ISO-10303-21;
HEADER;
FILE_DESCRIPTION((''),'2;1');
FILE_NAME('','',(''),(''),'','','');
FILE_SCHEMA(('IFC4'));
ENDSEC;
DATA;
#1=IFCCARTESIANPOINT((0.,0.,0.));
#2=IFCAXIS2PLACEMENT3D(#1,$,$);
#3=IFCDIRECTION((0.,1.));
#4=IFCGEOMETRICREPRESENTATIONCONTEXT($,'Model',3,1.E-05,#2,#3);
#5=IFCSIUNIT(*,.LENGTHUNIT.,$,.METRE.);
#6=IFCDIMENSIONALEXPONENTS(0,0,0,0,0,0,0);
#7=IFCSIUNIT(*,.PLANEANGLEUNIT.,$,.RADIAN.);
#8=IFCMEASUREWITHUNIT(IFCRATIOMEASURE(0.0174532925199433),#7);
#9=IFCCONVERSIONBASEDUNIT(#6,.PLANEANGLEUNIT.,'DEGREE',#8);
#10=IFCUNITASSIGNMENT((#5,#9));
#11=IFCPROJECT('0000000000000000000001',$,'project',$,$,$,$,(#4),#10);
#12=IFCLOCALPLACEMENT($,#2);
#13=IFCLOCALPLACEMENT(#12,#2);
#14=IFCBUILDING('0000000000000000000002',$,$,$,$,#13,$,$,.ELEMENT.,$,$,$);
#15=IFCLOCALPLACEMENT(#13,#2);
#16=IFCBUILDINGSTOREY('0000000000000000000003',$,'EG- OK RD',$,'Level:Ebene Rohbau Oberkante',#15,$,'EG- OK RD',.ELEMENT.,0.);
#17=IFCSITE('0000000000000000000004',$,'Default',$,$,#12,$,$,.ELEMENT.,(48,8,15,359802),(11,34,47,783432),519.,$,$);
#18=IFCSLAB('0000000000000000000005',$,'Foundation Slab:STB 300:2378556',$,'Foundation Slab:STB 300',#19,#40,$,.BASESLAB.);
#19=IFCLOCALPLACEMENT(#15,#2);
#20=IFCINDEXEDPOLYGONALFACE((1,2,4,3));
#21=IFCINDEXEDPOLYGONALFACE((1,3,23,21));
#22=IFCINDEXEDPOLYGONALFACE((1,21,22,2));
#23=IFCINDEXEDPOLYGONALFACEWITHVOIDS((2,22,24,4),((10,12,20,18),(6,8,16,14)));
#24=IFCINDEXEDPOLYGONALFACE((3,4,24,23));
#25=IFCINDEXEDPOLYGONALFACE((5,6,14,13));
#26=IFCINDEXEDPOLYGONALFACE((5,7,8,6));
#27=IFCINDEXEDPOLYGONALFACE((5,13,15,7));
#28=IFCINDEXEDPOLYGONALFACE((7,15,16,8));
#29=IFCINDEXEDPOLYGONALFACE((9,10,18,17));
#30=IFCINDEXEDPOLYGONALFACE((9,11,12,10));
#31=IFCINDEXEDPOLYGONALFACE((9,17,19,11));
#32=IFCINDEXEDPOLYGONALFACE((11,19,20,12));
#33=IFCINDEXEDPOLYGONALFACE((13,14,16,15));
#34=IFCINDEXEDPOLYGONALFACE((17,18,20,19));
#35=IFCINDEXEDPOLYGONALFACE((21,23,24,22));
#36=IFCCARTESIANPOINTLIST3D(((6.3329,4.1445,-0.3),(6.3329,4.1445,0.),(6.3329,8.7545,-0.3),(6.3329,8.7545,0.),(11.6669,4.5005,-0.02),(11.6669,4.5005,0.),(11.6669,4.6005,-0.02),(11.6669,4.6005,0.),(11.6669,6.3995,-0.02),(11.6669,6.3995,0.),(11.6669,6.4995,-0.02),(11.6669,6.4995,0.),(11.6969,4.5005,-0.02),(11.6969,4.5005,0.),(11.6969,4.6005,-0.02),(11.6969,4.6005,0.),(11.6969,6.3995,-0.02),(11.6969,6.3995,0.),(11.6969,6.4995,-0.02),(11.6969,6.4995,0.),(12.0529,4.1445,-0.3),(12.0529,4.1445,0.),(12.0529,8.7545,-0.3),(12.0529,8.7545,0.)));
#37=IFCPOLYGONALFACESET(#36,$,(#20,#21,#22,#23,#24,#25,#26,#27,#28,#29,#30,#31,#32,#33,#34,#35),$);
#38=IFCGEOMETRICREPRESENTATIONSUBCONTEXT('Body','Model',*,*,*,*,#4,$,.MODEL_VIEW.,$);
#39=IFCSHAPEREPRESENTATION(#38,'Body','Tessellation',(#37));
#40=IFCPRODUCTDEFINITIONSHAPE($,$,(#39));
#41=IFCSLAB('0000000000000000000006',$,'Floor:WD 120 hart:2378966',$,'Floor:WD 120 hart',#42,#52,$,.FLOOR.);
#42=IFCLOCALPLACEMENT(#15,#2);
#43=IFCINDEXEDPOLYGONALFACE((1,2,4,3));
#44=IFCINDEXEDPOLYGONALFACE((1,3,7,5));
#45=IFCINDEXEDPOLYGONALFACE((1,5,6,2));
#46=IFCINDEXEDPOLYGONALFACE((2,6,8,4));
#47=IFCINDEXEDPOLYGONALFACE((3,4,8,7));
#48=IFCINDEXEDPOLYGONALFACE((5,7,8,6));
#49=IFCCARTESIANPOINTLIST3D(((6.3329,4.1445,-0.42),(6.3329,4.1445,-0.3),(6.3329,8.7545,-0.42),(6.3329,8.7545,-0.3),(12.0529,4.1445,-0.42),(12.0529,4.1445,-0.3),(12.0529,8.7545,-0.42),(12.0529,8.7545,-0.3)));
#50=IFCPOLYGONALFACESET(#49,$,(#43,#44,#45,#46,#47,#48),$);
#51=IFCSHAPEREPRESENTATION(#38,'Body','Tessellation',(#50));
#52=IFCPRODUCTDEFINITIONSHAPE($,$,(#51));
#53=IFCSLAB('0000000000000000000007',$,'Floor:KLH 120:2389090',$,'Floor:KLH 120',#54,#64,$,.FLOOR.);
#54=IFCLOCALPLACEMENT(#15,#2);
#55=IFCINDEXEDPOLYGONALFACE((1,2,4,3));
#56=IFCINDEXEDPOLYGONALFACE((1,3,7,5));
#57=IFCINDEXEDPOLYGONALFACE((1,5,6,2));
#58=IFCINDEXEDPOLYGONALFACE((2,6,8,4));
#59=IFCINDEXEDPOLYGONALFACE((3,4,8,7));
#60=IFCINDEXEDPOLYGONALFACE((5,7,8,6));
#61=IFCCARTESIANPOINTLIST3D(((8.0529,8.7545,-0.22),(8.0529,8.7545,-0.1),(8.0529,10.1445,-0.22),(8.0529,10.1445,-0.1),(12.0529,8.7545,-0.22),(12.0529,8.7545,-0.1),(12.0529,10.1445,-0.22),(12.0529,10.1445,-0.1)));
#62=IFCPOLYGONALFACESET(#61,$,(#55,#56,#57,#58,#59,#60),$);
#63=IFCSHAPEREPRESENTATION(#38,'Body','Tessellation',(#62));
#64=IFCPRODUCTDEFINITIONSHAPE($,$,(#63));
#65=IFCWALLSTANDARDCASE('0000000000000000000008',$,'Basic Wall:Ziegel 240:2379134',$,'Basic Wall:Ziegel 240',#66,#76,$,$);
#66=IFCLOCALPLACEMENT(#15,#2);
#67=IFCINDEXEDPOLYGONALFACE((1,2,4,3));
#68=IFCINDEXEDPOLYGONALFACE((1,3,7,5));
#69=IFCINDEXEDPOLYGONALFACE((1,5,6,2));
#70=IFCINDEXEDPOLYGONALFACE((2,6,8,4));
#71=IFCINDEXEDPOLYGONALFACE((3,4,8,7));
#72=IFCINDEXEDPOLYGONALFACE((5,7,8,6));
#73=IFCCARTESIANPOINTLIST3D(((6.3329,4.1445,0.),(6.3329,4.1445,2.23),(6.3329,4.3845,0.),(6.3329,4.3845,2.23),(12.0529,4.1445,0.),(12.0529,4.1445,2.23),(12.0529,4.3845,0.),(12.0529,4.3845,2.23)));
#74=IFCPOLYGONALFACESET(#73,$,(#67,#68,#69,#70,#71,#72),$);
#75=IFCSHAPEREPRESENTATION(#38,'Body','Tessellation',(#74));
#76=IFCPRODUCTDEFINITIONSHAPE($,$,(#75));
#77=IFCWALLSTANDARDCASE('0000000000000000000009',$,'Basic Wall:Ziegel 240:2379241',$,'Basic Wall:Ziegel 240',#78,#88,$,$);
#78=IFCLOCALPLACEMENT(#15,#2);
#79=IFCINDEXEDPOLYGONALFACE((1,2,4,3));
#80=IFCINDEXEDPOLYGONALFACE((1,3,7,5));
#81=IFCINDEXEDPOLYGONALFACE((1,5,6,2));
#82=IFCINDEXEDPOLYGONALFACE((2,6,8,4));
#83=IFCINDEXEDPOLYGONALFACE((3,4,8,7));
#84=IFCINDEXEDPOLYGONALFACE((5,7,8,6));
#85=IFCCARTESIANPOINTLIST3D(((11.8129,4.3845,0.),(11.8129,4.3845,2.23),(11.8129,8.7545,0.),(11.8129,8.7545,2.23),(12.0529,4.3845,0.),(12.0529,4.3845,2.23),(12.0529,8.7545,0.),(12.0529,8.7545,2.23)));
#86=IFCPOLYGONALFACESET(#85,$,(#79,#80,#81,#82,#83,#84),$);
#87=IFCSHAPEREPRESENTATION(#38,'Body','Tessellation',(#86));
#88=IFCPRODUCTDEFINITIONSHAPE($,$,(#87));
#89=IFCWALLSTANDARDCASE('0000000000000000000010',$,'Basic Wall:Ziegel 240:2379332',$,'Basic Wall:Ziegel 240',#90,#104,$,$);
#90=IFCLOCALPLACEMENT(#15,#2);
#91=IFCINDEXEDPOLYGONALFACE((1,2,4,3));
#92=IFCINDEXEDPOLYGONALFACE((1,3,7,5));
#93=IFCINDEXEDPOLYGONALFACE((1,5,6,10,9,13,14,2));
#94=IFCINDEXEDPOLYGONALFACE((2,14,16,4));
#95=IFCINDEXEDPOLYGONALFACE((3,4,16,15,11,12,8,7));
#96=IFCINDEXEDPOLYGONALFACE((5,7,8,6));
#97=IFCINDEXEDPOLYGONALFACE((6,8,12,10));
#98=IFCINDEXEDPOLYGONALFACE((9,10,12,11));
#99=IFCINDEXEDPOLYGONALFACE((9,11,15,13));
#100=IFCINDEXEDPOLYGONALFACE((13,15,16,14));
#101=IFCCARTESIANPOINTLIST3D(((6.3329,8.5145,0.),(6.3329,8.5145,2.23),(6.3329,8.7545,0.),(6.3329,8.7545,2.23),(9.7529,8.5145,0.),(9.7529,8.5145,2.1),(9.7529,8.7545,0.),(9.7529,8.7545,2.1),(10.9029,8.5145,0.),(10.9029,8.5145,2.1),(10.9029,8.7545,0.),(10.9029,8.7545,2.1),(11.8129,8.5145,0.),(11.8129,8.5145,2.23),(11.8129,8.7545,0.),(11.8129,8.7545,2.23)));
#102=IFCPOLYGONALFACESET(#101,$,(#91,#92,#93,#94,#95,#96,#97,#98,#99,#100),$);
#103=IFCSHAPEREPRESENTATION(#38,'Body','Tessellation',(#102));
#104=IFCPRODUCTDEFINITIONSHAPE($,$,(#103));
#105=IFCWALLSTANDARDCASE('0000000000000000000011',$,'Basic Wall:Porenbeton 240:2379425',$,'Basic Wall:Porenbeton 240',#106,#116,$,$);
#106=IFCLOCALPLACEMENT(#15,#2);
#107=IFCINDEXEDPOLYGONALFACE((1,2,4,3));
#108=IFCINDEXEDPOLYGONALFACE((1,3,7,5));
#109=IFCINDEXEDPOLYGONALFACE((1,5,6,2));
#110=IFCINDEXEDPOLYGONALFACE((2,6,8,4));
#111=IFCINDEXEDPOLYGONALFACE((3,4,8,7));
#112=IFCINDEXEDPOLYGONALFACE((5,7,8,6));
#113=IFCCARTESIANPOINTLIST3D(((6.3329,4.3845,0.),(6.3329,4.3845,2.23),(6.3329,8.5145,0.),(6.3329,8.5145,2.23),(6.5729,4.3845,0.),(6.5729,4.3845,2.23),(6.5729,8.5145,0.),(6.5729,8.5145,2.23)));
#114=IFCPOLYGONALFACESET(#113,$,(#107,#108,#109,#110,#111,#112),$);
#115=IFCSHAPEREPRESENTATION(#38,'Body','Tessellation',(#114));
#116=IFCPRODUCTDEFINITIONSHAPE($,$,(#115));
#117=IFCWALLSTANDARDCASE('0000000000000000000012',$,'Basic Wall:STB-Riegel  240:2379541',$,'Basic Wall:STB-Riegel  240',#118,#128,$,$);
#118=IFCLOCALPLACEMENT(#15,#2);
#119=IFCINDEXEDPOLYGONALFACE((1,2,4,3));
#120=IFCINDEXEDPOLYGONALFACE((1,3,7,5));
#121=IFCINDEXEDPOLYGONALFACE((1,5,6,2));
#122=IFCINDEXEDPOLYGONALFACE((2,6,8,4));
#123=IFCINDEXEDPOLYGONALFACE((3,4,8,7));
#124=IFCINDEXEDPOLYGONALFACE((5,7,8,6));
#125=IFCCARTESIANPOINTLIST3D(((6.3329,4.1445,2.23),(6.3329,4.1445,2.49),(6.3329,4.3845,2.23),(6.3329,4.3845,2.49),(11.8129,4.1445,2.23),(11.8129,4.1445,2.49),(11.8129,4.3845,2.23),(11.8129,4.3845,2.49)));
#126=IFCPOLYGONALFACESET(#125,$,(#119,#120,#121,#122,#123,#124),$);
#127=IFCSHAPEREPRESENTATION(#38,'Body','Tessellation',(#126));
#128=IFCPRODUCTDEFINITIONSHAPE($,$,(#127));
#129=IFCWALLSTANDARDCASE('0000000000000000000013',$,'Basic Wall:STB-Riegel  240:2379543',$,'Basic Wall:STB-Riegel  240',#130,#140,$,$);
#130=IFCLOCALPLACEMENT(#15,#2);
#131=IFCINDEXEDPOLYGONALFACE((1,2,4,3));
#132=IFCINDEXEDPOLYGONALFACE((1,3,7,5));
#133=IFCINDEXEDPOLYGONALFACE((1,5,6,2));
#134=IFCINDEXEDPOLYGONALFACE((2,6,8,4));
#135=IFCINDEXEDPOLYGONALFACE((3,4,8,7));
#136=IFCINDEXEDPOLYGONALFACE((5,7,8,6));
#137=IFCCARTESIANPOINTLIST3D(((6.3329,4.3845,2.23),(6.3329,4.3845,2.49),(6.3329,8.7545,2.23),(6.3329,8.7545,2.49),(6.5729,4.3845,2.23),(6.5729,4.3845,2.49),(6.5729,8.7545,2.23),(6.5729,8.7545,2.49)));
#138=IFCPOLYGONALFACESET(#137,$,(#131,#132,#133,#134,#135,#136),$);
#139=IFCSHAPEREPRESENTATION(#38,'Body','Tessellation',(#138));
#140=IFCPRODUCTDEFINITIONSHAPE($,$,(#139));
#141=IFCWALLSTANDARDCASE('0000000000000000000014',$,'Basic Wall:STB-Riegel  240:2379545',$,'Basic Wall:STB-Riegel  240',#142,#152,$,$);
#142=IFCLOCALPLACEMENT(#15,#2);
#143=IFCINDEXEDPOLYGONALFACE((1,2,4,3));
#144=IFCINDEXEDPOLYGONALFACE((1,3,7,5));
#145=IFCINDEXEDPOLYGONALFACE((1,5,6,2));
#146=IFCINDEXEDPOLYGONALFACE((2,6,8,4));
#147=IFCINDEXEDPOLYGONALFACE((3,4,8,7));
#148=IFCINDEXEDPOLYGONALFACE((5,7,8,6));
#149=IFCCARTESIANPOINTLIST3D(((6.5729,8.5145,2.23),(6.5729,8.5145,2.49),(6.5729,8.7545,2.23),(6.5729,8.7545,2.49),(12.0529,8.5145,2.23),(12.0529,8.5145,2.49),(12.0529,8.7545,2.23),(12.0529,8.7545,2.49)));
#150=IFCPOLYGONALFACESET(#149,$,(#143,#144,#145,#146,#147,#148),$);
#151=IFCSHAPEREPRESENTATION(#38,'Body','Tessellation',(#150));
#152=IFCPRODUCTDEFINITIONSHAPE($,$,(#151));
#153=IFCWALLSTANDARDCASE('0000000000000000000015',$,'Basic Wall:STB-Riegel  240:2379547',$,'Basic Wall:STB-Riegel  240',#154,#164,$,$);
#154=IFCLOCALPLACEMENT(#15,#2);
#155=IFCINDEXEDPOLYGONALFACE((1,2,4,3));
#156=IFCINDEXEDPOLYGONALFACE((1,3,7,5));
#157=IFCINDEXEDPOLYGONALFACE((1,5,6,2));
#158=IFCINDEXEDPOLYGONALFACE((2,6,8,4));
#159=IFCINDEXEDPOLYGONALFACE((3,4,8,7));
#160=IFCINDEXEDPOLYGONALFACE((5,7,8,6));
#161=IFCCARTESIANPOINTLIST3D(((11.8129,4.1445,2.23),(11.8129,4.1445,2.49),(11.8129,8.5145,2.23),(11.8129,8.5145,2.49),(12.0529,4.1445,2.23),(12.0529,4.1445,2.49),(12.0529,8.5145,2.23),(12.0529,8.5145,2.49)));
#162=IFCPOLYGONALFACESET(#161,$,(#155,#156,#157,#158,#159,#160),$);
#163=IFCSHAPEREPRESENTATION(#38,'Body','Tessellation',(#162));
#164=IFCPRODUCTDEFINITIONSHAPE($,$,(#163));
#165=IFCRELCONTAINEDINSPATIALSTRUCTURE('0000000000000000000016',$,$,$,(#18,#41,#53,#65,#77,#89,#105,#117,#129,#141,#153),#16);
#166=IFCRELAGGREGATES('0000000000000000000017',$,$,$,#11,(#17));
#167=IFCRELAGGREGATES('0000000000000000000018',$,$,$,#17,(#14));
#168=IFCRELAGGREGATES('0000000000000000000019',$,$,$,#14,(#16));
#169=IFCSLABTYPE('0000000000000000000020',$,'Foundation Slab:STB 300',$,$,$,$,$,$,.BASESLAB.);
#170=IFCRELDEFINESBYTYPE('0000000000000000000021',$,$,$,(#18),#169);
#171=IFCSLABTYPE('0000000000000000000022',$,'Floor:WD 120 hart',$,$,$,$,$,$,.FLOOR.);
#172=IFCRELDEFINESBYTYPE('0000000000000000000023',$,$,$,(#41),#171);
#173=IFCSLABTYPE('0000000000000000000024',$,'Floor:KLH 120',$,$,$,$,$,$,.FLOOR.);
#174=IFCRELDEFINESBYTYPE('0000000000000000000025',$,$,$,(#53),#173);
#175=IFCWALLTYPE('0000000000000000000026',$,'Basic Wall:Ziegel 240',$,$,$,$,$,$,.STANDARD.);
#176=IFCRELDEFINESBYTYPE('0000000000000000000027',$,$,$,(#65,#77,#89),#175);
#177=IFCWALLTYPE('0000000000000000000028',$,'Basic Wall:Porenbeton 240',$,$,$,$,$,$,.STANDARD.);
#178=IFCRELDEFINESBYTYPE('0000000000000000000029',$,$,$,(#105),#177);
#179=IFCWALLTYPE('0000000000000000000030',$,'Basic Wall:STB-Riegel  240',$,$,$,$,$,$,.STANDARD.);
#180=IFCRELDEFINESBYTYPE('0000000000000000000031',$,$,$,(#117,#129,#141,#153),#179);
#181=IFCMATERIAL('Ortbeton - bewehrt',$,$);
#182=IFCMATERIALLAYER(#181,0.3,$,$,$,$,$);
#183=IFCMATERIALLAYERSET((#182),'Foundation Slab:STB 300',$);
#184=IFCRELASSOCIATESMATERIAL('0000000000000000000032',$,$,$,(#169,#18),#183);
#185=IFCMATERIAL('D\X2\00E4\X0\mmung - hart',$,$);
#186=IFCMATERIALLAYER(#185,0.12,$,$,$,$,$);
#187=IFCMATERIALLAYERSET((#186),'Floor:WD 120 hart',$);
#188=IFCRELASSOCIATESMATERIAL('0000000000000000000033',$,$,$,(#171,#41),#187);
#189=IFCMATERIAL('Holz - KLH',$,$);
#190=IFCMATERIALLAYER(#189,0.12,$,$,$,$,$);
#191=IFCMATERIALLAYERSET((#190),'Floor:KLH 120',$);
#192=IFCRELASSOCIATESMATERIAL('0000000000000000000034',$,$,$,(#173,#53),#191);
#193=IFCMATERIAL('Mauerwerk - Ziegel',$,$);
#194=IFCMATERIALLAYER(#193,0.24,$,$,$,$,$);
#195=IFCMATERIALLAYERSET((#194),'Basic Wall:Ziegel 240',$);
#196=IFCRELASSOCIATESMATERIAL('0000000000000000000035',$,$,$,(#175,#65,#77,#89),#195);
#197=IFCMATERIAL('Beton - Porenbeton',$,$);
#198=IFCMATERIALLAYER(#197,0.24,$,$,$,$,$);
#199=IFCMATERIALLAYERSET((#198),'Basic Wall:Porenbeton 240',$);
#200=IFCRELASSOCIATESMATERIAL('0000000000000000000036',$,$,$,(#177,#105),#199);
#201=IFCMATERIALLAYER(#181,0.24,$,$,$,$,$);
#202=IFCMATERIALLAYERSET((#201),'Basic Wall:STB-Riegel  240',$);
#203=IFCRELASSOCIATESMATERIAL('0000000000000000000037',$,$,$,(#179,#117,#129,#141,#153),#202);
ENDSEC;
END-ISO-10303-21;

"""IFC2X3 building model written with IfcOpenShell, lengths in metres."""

from ifc_helpers import new_model, entity, si_unit, converted_unit, direction, frame, frame_2d, origin, origin_2d_with_axis, place, context, subcontext, project, spatial, rectangle, extrude, material, layer, layer_set, layer_usage, type_object, element, save


model = new_model("IFC2X3")

# Units and contexts
model_context = context("Model", 3, precision=1e-05, world=origin(), true_north=direction((0.0, 1.0)))
body_context = subcontext(model_context, "Body", "Model", "MODEL_VIEW")
ifc_project = project(units=[si_unit("LENGTHUNIT", "METRE"), converted_unit("PLANEANGLEUNIT", "DEGREE", entity("IfcRatioMeasure", 0.0174532925199433), si_unit("PLANEANGLEUNIT", "RADIAN"), dimensions=[0, 0, 0, 0, 0, 0, 0])], contexts=[model_context])

# Site, building, storey
site_placement = place(None, origin())
site = spatial("IfcSite", under=ifc_project, at=site_placement, Name="Default", CompositionType="ELEMENT", RefLatitude=(48, 8, 15, 359802), RefLongitude=(11, 34, 47, 783432), RefElevation=519.0)
building_placement = place(site_placement, origin())
building = spatial("IfcBuilding", under=site, at=building_placement, CompositionType="ELEMENT")
storey_placement = place(building_placement, origin())
storey = spatial("IfcBuildingStorey", under=building, at=storey_placement, Name="EG- OK RD", ObjectType="Level:Ebene Rohbau Oberkante", LongName="EG- OK RD", CompositionType="ELEMENT", Elevation=0.0)

# Slab, openings
ifc_material_1 = material(Name="Ortbeton - bewehrt")
ifc_layer_1 = layer(ifc_material_1, 0.3)
ifc_layer_set_1 = layer_set([ifc_layer_1], Name="Foundation Slab:STB 300")
ifc_layer_usage_1 = layer_usage(ifc_layer_set_1, "AXIS3", "POSITIVE", 0.0)
slab_type_1 = type_object("IfcSlabType", Name="Foundation Slab:STB 300", PredefinedType="BASESLAB", material=ifc_layer_set_1)
slab_1_placement = place(storey_placement, frame((6.3329, 4.1445, -0.3)))
slab_1 = element("IfcSlab", 1, at=slab_1_placement, inside=storey, type_object=slab_type_1, material=ifc_layer_usage_1, Name="Foundation Slab:STB 300:2378556", ObjectType="Foundation Slab:STB 300", PredefinedType="BASESLAB", context=body_context, shape_type="SweptSolid", body=[
    extrude(rectangle(XDim=4.61, YDim=5.72, at=frame_2d((0.0, 0.0), x_axis=(0.0, -1.0))), frame((2.86, 2.305, 0.3), z_axis=(0.0, 0.0, -1.0), x_axis=(-1.0, 0.0, 0.0)), (0.0, 0.0, 1.0), 0.3),
])
opening_1_placement = place(slab_1_placement, origin())
element("IfcOpeningElement", 2, at=opening_1_placement, cuts=slab_1, ObjectType="Opening", context=body_context, shape_type="SweptSolid", body=[
    extrude(rectangle(XDim=0.03, YDim=0.1, at=origin_2d_with_axis()), frame((5.349, 2.305, 0.28), z_axis=(0.0, 0.0, 1.0), x_axis=(-1.0, 0.0, 0.0)), (0.0, 0.0, 1.0), 0.52),
])
opening_2_placement = place(slab_1_placement, origin())
element("IfcOpeningElement", 3, at=opening_2_placement, cuts=slab_1, ObjectType="Recess", context=body_context, shape_type="SweptSolid", body=[
    extrude(rectangle(XDim=0.03, YDim=0.1, at=origin_2d_with_axis()), frame((5.349, 0.406, 0.28), z_axis=(0.0, 0.0, 1.0), x_axis=(-1.0, 0.0, 0.0)), (0.0, 0.0, 1.0), 0.52),
])

# Slabs
ifc_material_2 = material(Name="Dämmung - hart")
ifc_layer_2 = layer(ifc_material_2, 0.12)
ifc_layer_set_2 = layer_set([ifc_layer_2], Name="Floor:WD 120 hart")
ifc_layer_usage_2 = layer_usage(ifc_layer_set_2, "AXIS3", "POSITIVE", 0.0)
slab_type_2 = type_object("IfcSlabType", Name="Floor:WD 120 hart", PredefinedType="FLOOR", material=ifc_layer_set_2)
slab_2_placement = place(storey_placement, origin())
element("IfcSlab", 4, at=slab_2_placement, inside=storey, type_object=slab_type_2, material=ifc_layer_usage_2, Name="Floor:WD 120 hart:2378966", ObjectType="Floor:WD 120 hart", PredefinedType="FLOOR", context=body_context, shape_type="SweptSolid", body=[
    extrude(rectangle(XDim=4.61, YDim=5.72, at=frame_2d((0.0, 0.0), x_axis=(1.0, 0.0))), frame((9.1929, 6.4495, -0.3), z_axis=(0.0, 0.0, -1.0), x_axis=(0.0, 1.0, 0.0)), (0.0, 0.0, 1.0), 0.12),
])
ifc_material_3 = material(Name="Holz - KLH")
ifc_layer_3 = layer(ifc_material_3, 0.12)
ifc_layer_set_3 = layer_set([ifc_layer_3], Name="Floor:KLH 120")
ifc_layer_usage_3 = layer_usage(ifc_layer_set_3, "AXIS3", "POSITIVE", 0.0)
slab_type_3 = type_object("IfcSlabType", Name="Floor:KLH 120", PredefinedType="FLOOR", material=ifc_layer_set_3)
slab_3_placement = place(storey_placement, origin())
element("IfcSlab", 5, at=slab_3_placement, inside=storey, type_object=slab_type_3, material=ifc_layer_usage_3, Name="Floor:KLH 120:2389090", ObjectType="Floor:KLH 120", PredefinedType="FLOOR", context=body_context, shape_type="SweptSolid", body=[
    extrude(rectangle(XDim=1.39, YDim=4.0, at=frame_2d((0.0, 0.0), x_axis=(1.0, 0.0))), frame((10.0529, 9.4495, -0.1), z_axis=(0.0, 0.0, -1.0), x_axis=(0.0, 1.0, 0.0)), (0.0, 0.0, 1.0), 0.12),
])

# Walls
ifc_material_4 = material(Name="Mauerwerk - Ziegel")
ifc_layer_4 = layer(ifc_material_4, 0.24)
ifc_layer_set_4 = layer_set([ifc_layer_4], Name="Basic Wall:Ziegel 240")
ifc_layer_usage_4 = layer_usage(ifc_layer_set_4, "AXIS2", "POSITIVE", -0.12)
wall_type_1 = type_object("IfcWallType", Name="Basic Wall:Ziegel 240", PredefinedType="STANDARD", material=ifc_layer_set_4)
wall_1_placement = place(storey_placement, frame((6.3329, 4.2645, 0.0)))
element("IfcWallStandardCase", 6, at=wall_1_placement, inside=storey, type_object=wall_type_1, material=ifc_layer_usage_4, Name="Basic Wall:Ziegel 240:2379134", ObjectType="Basic Wall:Ziegel 240", context=body_context, shape_type="SweptSolid", body=[
    extrude(rectangle(XDim=5.72, YDim=0.24, at=frame_2d((2.86, 0.0), x_axis=(-1.0, 0.0))), origin(), (0.0, 0.0, 1.0), 2.23),
])
ifc_layer_usage_5 = layer_usage(ifc_layer_set_4, "AXIS2", "POSITIVE", -0.12)
wall_2_placement = place(storey_placement, frame((11.9329, 4.3845, 0.0), z_axis=(0.0, 0.0, 1.0), x_axis=(0.0, 1.0, 0.0)))
element("IfcWallStandardCase", 7, at=wall_2_placement, inside=storey, type_object=wall_type_1, material=ifc_layer_usage_5, Name="Basic Wall:Ziegel 240:2379241", ObjectType="Basic Wall:Ziegel 240", context=body_context, shape_type="SweptSolid", body=[
    extrude(rectangle(XDim=4.37, YDim=0.24, at=frame_2d((2.185, 0.0), x_axis=(-1.0, 0.0))), origin(), (0.0, 0.0, 1.0), 2.23),
])

# Wall, opening
ifc_layer_usage_6 = layer_usage(ifc_layer_set_4, "AXIS2", "POSITIVE", -0.12)
wall_3_placement = place(storey_placement, frame((11.8129, 8.6345, 0.0), z_axis=(0.0, 0.0, 1.0), x_axis=(-1.0, 0.0, 0.0)))
wall_3 = element("IfcWallStandardCase", 8, at=wall_3_placement, inside=storey, type_object=wall_type_1, material=ifc_layer_usage_6, Name="Basic Wall:Ziegel 240:2379332", ObjectType="Basic Wall:Ziegel 240", context=body_context, shape_type="SweptSolid", body=[
    extrude(rectangle(XDim=5.48, YDim=0.24, at=frame_2d((2.74, 0.0), x_axis=(-1.0, 0.0))), origin(), (0.0, 0.0, 1.0), 2.23),
])
opening_3_placement = place(wall_3_placement, frame((0.91, -0.12, 0.0)))
element("IfcOpeningElement", 9, at=opening_3_placement, cuts=wall_3, ObjectType="Opening", context=body_context, shape_type="SweptSolid", body=[
    extrude(rectangle(XDim=2.1, YDim=1.15, at=frame_2d((1.05, 0.575), x_axis=(-1.0, 0.0))), frame((0.0, 0.0, 0.0), z_axis=(0.0, 1.0, 0.0), x_axis=(0.0, 0.0, 1.0)), (0.0, 0.0, 1.0), 0.24),
])

# Walls
ifc_material_5 = material(Name="Beton - Porenbeton")
ifc_layer_5 = layer(ifc_material_5, 0.24)
ifc_layer_set_5 = layer_set([ifc_layer_5], Name="Basic Wall:Porenbeton 240")
ifc_layer_usage_7 = layer_usage(ifc_layer_set_5, "AXIS2", "POSITIVE", -0.12)
wall_type_2 = type_object("IfcWallType", Name="Basic Wall:Porenbeton 240", PredefinedType="STANDARD", material=ifc_layer_set_5)
wall_4_placement = place(storey_placement, frame((6.4529, 8.5145, 0.0), z_axis=(0.0, 0.0, 1.0), x_axis=(0.0, -1.0, 0.0)))
element("IfcWallStandardCase", 10, at=wall_4_placement, inside=storey, type_object=wall_type_2, material=ifc_layer_usage_7, Name="Basic Wall:Porenbeton 240:2379425", ObjectType="Basic Wall:Porenbeton 240", context=body_context, shape_type="SweptSolid", body=[
    extrude(rectangle(XDim=4.13, YDim=0.24, at=frame_2d((2.065, 0.0), x_axis=(-1.0, 0.0))), origin(), (0.0, 0.0, 1.0), 2.23),
])
ifc_layer_6 = layer(ifc_material_1, 0.24)
ifc_layer_set_6 = layer_set([ifc_layer_6], Name="Basic Wall:STB-Riegel  240")
ifc_layer_usage_8 = layer_usage(ifc_layer_set_6, "AXIS2", "NEGATIVE", 0.12)
wall_type_3 = type_object("IfcWallType", Name="Basic Wall:STB-Riegel  240", PredefinedType="STANDARD", material=ifc_layer_set_6)
wall_5_placement = place(storey_placement, frame((6.3329, 4.2645, 2.23)))
element("IfcWallStandardCase", 11, at=wall_5_placement, inside=storey, type_object=wall_type_3, material=ifc_layer_usage_8, Name="Basic Wall:STB-Riegel  240:2379541", ObjectType="Basic Wall:STB-Riegel  240", context=body_context, shape_type="SweptSolid", body=[
    extrude(rectangle(XDim=5.48, YDim=0.24, at=frame_2d((2.74, 0.0), x_axis=(-1.0, 0.0))), origin(), (0.0, 0.0, 1.0), 0.26),
])
ifc_layer_usage_9 = layer_usage(ifc_layer_set_6, "AXIS2", "NEGATIVE", 0.12)
wall_6_placement = place(storey_placement, frame((6.4529, 8.7545, 2.23), z_axis=(0.0, 0.0, 1.0), x_axis=(0.0, -1.0, 0.0)))
element("IfcWallStandardCase", 12, at=wall_6_placement, inside=storey, type_object=wall_type_3, material=ifc_layer_usage_9, Name="Basic Wall:STB-Riegel  240:2379543", ObjectType="Basic Wall:STB-Riegel  240", context=body_context, shape_type="SweptSolid", body=[
    extrude(rectangle(XDim=4.37, YDim=0.24, at=frame_2d((2.185, 0.0), x_axis=(-1.0, 0.0))), origin(), (0.0, 0.0, 1.0), 0.26),
])
ifc_layer_usage_10 = layer_usage(ifc_layer_set_6, "AXIS2", "NEGATIVE", 0.12)
wall_7_placement = place(storey_placement, frame((12.0529, 8.6345, 2.23), z_axis=(0.0, 0.0, 1.0), x_axis=(-1.0, 0.0, 0.0)))
element("IfcWallStandardCase", 13, at=wall_7_placement, inside=storey, type_object=wall_type_3, material=ifc_layer_usage_10, Name="Basic Wall:STB-Riegel  240:2379545", ObjectType="Basic Wall:STB-Riegel  240", context=body_context, shape_type="SweptSolid", body=[
    extrude(rectangle(XDim=5.48, YDim=0.24, at=frame_2d((2.74, 0.0), x_axis=(-1.0, 0.0))), origin(), (0.0, 0.0, 1.0), 0.26),
])
ifc_layer_usage_11 = layer_usage(ifc_layer_set_6, "AXIS2", "NEGATIVE", 0.12)
wall_8_placement = place(storey_placement, frame((11.9329, 4.1445, 2.23), z_axis=(0.0, 0.0, 1.0), x_axis=(0.0, 1.0, 0.0)))
element("IfcWallStandardCase", 14, at=wall_8_placement, inside=storey, type_object=wall_type_3, material=ifc_layer_usage_11, Name="Basic Wall:STB-Riegel  240:2379547", ObjectType="Basic Wall:STB-Riegel  240", context=body_context, shape_type="SweptSolid", body=[
    extrude(rectangle(XDim=4.37, YDim=0.24, at=frame_2d((2.185, 0.0), x_axis=(-1.0, 0.0))), origin(), (0.0, 0.0, 1.0), 0.26),
])

save(model, "model.ifc")
